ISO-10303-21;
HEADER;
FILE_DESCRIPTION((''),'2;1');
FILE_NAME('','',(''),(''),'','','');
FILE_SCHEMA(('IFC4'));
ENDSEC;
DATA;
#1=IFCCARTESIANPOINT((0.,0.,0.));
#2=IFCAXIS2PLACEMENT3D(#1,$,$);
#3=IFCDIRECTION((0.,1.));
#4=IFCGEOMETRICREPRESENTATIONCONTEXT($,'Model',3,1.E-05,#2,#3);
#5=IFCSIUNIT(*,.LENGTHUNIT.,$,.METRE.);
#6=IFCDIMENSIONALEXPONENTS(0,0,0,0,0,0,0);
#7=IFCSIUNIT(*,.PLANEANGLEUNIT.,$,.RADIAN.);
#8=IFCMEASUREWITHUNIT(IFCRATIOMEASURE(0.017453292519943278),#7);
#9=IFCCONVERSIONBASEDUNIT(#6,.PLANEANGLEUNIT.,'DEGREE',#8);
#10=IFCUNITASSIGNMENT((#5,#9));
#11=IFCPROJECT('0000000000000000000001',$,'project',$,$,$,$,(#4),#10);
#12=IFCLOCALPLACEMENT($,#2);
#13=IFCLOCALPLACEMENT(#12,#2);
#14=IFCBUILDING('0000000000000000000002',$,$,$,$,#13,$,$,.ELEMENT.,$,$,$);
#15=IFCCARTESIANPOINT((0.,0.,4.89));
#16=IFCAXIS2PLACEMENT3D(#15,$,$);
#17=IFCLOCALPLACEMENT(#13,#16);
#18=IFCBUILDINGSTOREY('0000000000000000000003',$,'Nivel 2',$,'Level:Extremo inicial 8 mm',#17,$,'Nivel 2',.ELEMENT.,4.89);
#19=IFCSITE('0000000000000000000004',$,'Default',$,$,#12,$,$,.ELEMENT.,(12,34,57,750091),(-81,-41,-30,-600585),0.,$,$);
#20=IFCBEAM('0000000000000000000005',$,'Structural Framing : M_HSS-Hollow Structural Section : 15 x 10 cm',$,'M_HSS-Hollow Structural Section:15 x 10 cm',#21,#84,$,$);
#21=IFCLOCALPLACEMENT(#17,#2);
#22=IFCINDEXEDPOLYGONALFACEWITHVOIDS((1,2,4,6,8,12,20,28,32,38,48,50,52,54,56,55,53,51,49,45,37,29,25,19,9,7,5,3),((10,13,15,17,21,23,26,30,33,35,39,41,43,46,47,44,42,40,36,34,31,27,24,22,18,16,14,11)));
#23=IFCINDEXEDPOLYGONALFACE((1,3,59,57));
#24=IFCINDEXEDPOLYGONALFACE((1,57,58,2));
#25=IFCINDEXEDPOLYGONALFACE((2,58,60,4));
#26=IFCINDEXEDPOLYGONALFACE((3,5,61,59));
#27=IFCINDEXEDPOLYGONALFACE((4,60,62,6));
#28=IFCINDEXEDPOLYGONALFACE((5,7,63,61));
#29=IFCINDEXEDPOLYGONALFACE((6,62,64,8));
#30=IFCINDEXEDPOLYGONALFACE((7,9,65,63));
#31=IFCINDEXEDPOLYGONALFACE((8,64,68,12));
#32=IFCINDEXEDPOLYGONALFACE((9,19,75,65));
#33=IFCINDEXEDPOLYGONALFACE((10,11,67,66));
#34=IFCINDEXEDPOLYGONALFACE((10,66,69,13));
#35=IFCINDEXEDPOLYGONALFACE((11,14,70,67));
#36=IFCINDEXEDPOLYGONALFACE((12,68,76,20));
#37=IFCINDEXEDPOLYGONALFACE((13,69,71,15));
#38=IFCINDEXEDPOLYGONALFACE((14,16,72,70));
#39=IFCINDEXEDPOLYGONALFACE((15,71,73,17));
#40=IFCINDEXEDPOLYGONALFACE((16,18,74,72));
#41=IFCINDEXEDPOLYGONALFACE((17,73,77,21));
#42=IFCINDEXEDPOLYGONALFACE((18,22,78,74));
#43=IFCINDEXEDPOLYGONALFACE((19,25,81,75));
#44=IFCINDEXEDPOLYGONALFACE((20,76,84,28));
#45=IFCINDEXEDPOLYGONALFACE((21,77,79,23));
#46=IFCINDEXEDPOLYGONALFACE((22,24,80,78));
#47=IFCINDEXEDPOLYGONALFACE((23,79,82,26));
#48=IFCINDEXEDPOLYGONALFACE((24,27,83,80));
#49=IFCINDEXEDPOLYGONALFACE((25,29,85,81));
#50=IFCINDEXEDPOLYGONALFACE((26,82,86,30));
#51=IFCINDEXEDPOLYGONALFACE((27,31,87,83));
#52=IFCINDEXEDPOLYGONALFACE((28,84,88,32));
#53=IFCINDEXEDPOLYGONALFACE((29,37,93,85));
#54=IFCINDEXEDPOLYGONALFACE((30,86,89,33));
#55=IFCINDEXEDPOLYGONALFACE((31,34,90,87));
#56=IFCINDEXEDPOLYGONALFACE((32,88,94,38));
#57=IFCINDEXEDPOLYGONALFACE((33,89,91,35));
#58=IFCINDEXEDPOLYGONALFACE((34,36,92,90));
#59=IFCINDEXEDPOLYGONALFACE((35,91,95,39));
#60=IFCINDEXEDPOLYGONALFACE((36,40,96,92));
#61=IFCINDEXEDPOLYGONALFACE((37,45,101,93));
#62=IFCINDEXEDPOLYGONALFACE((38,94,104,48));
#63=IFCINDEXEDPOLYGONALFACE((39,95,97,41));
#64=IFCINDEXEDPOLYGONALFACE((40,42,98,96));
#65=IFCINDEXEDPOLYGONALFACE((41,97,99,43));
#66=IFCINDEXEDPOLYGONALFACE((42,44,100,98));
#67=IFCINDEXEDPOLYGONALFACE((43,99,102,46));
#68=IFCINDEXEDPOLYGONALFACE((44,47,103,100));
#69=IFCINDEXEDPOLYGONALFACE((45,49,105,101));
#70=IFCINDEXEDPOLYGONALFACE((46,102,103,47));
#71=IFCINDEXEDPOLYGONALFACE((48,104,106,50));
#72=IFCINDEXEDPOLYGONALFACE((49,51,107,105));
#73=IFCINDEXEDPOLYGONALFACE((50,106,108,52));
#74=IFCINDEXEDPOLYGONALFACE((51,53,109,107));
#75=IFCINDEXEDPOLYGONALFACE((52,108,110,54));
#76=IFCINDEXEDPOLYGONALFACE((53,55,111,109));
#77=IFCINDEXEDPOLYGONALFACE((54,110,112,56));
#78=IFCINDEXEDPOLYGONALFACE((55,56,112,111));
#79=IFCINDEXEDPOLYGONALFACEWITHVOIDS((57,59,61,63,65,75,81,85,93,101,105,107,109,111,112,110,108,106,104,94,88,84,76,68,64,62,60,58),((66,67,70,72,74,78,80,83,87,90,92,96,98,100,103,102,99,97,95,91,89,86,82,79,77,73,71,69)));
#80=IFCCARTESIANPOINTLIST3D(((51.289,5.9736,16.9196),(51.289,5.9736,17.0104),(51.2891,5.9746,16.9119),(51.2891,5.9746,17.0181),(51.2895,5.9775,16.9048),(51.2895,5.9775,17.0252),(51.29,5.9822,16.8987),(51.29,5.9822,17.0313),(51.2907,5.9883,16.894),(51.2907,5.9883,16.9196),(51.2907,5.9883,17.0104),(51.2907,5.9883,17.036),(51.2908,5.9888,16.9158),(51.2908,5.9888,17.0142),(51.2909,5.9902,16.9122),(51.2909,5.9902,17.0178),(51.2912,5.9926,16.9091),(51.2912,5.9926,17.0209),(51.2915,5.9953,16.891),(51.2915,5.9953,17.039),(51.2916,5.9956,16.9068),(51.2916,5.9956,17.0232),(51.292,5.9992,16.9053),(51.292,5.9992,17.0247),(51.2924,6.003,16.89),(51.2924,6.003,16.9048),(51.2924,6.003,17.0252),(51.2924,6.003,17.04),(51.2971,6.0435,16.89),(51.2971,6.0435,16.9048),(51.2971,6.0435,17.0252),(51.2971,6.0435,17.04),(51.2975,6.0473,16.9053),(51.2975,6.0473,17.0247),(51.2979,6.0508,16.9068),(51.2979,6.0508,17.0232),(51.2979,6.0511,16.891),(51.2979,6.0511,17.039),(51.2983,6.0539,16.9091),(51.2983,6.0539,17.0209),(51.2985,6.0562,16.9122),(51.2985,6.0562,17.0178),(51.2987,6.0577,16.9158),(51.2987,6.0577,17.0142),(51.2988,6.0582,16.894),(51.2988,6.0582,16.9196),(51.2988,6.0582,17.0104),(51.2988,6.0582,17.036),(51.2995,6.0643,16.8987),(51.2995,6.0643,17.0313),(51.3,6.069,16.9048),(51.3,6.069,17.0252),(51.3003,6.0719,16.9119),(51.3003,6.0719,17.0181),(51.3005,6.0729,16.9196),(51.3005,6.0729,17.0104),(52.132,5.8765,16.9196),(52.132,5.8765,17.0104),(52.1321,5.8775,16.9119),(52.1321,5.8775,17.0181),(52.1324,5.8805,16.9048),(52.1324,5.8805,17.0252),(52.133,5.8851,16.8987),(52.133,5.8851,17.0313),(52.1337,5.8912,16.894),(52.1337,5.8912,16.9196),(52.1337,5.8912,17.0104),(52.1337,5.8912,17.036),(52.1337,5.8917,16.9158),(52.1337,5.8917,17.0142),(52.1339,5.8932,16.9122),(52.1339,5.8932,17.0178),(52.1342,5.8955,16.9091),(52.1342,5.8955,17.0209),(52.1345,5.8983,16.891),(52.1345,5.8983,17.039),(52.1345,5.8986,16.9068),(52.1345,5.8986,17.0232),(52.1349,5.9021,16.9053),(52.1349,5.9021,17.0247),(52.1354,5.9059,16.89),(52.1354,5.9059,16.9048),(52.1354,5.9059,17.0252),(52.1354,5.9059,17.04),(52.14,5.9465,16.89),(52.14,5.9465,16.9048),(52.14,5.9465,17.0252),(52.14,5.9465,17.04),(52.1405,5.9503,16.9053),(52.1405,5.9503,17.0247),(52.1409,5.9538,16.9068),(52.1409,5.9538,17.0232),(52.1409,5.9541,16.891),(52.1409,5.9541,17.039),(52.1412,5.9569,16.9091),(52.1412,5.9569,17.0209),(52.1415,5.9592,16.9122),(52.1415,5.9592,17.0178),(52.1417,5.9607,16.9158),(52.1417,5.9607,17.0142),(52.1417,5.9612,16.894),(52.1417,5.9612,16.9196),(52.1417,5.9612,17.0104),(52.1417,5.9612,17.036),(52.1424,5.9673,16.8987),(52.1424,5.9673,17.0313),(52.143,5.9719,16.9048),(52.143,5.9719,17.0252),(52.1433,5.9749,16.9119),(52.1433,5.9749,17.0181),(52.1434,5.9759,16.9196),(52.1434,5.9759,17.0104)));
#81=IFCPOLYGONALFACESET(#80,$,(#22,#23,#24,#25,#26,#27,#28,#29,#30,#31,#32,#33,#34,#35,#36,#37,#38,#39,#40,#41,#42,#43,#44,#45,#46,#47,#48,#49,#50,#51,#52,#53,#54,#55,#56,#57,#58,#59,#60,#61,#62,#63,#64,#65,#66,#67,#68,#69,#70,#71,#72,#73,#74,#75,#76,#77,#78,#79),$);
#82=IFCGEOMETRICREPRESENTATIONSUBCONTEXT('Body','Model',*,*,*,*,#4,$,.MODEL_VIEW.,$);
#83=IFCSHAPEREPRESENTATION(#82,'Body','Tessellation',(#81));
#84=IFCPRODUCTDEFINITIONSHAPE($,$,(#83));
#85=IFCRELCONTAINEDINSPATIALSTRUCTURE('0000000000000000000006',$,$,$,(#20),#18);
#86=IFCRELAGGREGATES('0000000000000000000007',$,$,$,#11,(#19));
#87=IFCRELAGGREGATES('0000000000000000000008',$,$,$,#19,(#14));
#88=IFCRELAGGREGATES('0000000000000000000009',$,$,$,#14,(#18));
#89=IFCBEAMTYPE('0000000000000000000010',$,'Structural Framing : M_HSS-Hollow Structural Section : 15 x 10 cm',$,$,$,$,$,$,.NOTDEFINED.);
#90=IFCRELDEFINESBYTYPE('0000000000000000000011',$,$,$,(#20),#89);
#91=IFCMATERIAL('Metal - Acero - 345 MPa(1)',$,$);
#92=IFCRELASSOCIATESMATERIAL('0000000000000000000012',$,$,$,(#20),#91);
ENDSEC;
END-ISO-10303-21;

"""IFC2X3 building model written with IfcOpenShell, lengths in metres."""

from ifc_helpers import new_model, entity, si_unit, converted_unit, direction, frame, frame_2d, origin, place, context, subcontext, project, spatial, polyline, circle_curve, parameter, trimmed, segment, composite_curve, outline, extrude, material, type_object, element, save


model = new_model("IFC2X3")

# Units and contexts
model_context = context("Model", 3, precision=1e-05, world=origin(), true_north=direction((0.0, 1.0)))
body_context = subcontext(model_context, "Body", "Model", "MODEL_VIEW")
ifc_project = project(units=[si_unit("LENGTHUNIT", "METRE"), converted_unit("PLANEANGLEUNIT", "DEGREE", entity("IfcRatioMeasure", 0.017453292519943278), si_unit("PLANEANGLEUNIT", "RADIAN"), dimensions=[0, 0, 0, 0, 0, 0, 0])], contexts=[model_context])

# Site, building, storey
site_placement = place(None, origin())
site = spatial("IfcSite", under=ifc_project, at=site_placement, Name="Default", CompositionType="ELEMENT", RefLatitude=(12, 34, 57, 750091), RefLongitude=(-81, -41, -30, -600585), RefElevation=0.0)
building_placement = place(site_placement, origin())
building = spatial("IfcBuilding", under=site, at=building_placement, CompositionType="ELEMENT")
storey_placement = place(building_placement, frame((0.0, 0.0, 4.89)))
storey = spatial("IfcBuildingStorey", under=building, at=storey_placement, Name="Nivel 2", ObjectType="Level:Extremo inicial 8 mm", LongName="Nivel 2", CompositionType="ELEMENT", Elevation=4.89)

# Shared definitions
ifc_material_1 = material(Name="Metal - Acero - 345 MPa(1)")

# Beam
beam_type_1 = type_object("IfcBeamType", Name="Structural Framing : M_HSS-Hollow Structural Section : 15 x 10 cm", PredefinedType="NOTDEFINED")
beam_1_placement = place(storey_placement, frame((52.4854, 5.8862, 17.04), z_axis=(0.0, 0.0, 1.0), x_axis=(-0.993441, 0.114344, 0.0)))
element("IfcBeam", 1, at=beam_1_placement, inside=storey, type_object=beam_type_1, material=ifc_material_1, Name="Structural Framing : M_HSS-Hollow Structural Section : 15 x 10 cm", ObjectType="M_HSS-Hollow Structural Section:15 x 10 cm", context=body_context, shape_type="SweptSolid", body=[
    extrude(outline(composite_curve([segment(trimmed(circle_curve(frame_2d((-0.0204, -0.0454), x_axis=(1.0, 0.0)), 0.0296), [parameter(180.0)], [parameter(270.0)], True, "PARAMETER"), True, "CONTINUOUS"), segment(polyline([(-0.0204, -0.075), (0.0204, -0.075)]), True, "CONTINUOUS"), segment(trimmed(circle_curve(frame_2d((0.0204, -0.0454), x_axis=(1.0, 0.0)), 0.0296), [parameter(270.0)], [parameter(0.0)], True, "PARAMETER"), True, "CONTINUOUS"), segment(polyline([(0.05, -0.0454), (0.05, 0.0454)]), True, "CONTINUOUS"), segment(trimmed(circle_curve(frame_2d((0.0204, 0.0454), x_axis=(1.0, 0.0)), 0.0296), [parameter(360.0)], [parameter(90.0)], True, "PARAMETER"), True, "CONTINUOUS"), segment(polyline([(0.0204, 0.075), (-0.0204, 0.075)]), True, "CONTINUOUS"), segment(trimmed(circle_curve(frame_2d((-0.0204, 0.0454), x_axis=(1.0, 0.0)), 0.0296), [parameter(90.0)], [parameter(180.0)], True, "PARAMETER"), True, "CONTINUOUS"), segment(polyline([(-0.05, 0.0454), (-0.05, -0.0454)]), True, "CONTINUOUS")], self_intersect=False), holes=[composite_curve([segment(polyline([(0.0204, -0.0602), (-0.0204, -0.0602)]), True, "CONTINUOUS"), segment(trimmed(circle_curve(frame_2d((-0.0204, -0.0454), x_axis=(1.0, 0.0)), 0.0148), [parameter(180.0)], [parameter(270.0)], True, "PARAMETER"), False, "CONTINUOUS"), segment(polyline([(-0.0352, -0.0454), (-0.0352, 0.0454)]), True, "CONTINUOUS"), segment(trimmed(circle_curve(frame_2d((-0.0204, 0.0454), x_axis=(1.0, 0.0)), 0.0148), [parameter(90.0)], [parameter(180.0)], True, "PARAMETER"), False, "CONTINUOUS"), segment(polyline([(-0.0204, 0.0602), (0.0204, 0.0602)]), True, "CONTINUOUS"), segment(trimmed(circle_curve(frame_2d((0.0204, 0.0454), x_axis=(1.0, 0.0)), 0.0148), [parameter(0.0)], [parameter(90.0)], True, "PARAMETER"), False, "CONTINUOUS"), segment(polyline([(0.0352, 0.0454), (0.0352, -0.0454)]), True, "CONTINUOUS"), segment(trimmed(circle_curve(frame_2d((0.0204, -0.0454), x_axis=(1.0, 0.0)), 0.0148), [parameter(270.0)], [parameter(0.0)], True, "PARAMETER"), False, "CONTINUOUS")], self_intersect=False)]), frame((0.35, 0.0, -0.075), z_axis=(1.0, 0.0, 0.0), x_axis=(0.0, -1.0, 0.0)), (0.0, 0.0, 1.0), 0.8485),
])

save(model, "model.ifc")
